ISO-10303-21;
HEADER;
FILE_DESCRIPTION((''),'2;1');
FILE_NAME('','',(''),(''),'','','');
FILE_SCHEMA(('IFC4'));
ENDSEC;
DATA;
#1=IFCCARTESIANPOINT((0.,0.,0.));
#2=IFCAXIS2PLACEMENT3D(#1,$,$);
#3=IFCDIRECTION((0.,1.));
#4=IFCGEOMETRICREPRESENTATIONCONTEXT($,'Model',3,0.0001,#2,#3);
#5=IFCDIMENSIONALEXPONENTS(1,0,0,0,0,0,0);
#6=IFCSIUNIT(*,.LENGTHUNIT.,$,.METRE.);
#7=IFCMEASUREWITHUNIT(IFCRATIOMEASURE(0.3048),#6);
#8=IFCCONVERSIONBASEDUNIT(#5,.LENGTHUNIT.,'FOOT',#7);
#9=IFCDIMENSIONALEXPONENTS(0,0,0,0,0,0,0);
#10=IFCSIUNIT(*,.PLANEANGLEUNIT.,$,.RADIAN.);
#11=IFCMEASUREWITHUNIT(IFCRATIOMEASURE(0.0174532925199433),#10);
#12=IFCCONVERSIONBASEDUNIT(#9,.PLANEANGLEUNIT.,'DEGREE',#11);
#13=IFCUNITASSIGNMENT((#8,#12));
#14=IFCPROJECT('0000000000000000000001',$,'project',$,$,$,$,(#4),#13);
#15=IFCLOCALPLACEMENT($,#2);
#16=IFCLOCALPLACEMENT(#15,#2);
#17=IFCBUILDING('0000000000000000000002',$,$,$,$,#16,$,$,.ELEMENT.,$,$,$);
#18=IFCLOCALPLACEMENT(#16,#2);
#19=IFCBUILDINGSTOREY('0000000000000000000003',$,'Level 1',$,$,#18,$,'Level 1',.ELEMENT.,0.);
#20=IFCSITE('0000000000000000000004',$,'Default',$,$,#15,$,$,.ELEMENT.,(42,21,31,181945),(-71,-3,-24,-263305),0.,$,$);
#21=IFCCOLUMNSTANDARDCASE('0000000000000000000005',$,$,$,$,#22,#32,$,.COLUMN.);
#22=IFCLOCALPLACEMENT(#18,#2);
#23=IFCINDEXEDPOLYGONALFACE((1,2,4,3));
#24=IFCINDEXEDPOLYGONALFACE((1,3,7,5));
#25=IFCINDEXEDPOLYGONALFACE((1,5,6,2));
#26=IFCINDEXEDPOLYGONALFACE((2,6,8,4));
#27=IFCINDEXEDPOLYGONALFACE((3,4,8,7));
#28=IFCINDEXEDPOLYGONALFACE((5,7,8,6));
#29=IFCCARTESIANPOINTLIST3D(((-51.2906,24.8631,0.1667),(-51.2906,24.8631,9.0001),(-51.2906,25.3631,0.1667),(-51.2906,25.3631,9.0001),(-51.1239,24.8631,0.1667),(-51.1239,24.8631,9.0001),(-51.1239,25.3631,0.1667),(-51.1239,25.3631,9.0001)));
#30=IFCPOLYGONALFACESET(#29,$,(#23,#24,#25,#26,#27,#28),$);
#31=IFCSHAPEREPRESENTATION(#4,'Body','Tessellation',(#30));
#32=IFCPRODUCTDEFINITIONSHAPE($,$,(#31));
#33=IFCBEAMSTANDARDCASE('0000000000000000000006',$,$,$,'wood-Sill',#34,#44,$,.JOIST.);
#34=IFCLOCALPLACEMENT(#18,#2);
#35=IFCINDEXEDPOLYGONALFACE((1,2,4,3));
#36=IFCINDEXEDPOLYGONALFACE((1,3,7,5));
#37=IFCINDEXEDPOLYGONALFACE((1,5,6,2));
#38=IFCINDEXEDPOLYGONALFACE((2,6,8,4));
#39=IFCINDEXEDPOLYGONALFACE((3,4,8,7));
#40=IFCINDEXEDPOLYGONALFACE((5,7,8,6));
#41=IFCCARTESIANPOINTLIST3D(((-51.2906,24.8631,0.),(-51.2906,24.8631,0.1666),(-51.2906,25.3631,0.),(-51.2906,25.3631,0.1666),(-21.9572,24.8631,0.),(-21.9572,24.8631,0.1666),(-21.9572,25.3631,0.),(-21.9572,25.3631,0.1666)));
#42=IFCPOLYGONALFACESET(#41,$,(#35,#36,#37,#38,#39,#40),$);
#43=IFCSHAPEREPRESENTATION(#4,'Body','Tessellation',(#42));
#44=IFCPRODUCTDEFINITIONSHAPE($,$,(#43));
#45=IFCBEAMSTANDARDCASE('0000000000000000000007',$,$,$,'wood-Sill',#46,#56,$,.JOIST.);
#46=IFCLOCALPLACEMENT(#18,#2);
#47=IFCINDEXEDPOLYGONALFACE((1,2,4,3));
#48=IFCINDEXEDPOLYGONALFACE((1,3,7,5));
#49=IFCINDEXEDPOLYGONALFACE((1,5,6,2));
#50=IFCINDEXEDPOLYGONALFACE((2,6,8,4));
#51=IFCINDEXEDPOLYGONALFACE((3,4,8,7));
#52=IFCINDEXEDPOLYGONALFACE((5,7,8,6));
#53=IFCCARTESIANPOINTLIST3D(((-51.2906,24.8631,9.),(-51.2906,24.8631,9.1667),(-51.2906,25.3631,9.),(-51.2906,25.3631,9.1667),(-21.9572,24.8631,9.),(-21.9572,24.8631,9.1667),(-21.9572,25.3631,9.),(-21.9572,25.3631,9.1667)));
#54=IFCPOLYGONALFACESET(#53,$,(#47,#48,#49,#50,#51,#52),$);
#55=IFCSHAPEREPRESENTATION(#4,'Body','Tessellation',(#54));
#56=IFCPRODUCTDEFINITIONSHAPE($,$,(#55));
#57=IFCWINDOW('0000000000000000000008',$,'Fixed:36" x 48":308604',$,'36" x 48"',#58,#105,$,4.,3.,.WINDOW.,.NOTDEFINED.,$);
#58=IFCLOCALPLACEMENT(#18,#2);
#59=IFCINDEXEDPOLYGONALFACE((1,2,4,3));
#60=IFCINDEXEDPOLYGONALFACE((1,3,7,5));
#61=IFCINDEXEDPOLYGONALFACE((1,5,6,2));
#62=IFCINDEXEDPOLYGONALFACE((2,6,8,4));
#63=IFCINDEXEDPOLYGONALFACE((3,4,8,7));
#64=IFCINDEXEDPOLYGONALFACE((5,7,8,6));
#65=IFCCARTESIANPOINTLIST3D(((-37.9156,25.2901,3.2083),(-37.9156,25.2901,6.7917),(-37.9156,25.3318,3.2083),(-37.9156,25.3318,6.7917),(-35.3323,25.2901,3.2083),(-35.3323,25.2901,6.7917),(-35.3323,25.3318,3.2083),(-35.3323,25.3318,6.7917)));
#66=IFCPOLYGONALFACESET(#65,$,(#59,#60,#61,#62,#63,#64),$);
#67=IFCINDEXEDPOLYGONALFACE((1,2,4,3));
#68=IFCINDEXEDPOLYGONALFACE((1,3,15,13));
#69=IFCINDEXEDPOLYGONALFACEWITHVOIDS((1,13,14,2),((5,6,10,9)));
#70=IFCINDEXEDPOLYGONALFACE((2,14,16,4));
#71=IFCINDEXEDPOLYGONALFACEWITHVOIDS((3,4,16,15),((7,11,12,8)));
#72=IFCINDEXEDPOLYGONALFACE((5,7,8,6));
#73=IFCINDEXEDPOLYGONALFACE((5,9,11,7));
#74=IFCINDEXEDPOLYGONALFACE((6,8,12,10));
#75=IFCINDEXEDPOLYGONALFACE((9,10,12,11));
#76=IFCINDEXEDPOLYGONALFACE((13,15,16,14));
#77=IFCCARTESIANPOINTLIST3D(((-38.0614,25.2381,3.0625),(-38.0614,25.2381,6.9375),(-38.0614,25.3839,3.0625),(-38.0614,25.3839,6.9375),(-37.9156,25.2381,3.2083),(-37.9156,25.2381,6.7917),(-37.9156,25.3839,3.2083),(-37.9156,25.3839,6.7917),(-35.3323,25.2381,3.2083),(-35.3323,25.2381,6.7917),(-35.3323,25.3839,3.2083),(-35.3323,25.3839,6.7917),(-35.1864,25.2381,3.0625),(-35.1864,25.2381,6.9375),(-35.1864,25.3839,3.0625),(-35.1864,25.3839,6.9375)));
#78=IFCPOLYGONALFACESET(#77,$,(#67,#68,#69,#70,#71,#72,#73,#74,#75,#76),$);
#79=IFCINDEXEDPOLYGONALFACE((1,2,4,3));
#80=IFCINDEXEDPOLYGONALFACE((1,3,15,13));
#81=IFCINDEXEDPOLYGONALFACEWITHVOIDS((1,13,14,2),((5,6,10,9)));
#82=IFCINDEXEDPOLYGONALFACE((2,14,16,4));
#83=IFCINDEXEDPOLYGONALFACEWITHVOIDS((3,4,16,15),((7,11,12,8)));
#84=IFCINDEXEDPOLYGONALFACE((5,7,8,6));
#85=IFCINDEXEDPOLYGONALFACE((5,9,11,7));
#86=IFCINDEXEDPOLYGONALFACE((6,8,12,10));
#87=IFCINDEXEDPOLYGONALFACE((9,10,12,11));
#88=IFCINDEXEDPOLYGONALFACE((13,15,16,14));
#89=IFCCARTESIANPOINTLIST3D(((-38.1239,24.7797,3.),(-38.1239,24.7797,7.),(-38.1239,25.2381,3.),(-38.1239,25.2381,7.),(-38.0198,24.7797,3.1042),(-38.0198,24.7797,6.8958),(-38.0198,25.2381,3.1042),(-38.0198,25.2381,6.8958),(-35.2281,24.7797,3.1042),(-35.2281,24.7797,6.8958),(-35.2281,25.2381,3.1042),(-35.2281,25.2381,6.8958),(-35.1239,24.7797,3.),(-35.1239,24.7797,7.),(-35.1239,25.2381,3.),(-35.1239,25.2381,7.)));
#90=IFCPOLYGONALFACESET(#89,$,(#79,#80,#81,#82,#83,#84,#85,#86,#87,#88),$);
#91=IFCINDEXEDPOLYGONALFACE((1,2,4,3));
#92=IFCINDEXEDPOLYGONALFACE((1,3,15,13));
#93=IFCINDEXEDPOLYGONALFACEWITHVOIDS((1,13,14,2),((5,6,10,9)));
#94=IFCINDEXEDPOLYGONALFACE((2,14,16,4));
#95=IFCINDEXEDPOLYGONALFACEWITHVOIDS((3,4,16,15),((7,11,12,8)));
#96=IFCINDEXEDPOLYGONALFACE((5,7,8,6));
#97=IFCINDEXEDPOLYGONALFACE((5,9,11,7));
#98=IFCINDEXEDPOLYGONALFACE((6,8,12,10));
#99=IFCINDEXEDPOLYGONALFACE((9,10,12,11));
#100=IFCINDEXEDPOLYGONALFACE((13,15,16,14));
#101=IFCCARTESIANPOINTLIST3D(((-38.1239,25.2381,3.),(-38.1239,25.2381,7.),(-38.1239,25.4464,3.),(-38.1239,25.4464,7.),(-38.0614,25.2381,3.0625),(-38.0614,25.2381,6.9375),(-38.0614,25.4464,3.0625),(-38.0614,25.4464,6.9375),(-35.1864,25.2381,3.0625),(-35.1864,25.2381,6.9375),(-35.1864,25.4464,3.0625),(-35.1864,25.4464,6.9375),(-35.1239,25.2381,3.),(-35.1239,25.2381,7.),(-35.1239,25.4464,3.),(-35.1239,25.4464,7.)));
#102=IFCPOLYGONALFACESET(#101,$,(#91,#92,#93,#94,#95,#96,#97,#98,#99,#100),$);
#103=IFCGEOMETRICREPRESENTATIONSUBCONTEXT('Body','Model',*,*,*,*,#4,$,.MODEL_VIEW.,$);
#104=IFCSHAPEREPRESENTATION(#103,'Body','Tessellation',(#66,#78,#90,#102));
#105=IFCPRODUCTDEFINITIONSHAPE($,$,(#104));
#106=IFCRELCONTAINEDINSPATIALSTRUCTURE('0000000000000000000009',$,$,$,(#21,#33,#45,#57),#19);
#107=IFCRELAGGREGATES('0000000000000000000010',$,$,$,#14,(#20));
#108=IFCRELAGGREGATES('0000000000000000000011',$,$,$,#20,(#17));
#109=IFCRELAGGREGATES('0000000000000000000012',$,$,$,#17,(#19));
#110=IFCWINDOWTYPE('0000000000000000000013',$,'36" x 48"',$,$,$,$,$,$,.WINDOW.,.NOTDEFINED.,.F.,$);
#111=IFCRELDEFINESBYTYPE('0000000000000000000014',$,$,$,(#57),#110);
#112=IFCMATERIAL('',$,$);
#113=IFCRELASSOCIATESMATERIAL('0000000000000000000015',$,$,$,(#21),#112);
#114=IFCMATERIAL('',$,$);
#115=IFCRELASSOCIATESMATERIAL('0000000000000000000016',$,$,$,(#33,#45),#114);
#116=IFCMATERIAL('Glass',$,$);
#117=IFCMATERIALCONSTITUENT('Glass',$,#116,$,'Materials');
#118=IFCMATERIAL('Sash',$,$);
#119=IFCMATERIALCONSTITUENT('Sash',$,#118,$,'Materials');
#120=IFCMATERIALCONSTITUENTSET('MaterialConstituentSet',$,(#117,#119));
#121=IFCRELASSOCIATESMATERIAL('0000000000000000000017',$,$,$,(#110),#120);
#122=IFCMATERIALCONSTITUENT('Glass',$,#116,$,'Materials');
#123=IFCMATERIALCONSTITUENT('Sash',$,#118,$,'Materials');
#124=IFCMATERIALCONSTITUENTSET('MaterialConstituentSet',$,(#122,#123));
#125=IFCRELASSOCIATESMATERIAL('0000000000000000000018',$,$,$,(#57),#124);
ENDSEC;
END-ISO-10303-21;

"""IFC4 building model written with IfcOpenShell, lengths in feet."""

from ifc_helpers import new_model, entity, si_unit, converted_unit, direction, frame, frame_2d, origin, origin_with_axes, place, context, subcontext, project, spatial, polyline, rectangle, outline, extrude, source, transform, mapped, material, constituent, constituent_set, type_object, type_shapes, element, save


model = new_model("IFC4")

# Units and contexts
model_context = context("Model", 3, precision=0.0001, world=origin(), true_north=direction((0.0, 1.0)))
body_context = subcontext(model_context, "Body", "Model", "MODEL_VIEW")
ifc_project = project(units=[converted_unit("LENGTHUNIT", "FOOT", entity("IfcRatioMeasure", 0.3048), si_unit("LENGTHUNIT", "METRE"), dimensions=[1, 0, 0, 0, 0, 0, 0]), converted_unit("PLANEANGLEUNIT", "DEGREE", entity("IfcRatioMeasure", 0.0174532925199433), si_unit("PLANEANGLEUNIT", "RADIAN"), dimensions=[0, 0, 0, 0, 0, 0, 0])], contexts=[model_context])

# Site, building, storey
site_placement = place(None, origin())
site = spatial("IfcSite", under=ifc_project, at=site_placement, Name="Default", CompositionType="ELEMENT", RefLatitude=(42, 21, 31, 181945), RefLongitude=(-71, -3, -24, -263305), RefElevation=0.0)
building_placement = place(site_placement, origin())
building = spatial("IfcBuilding", under=site, at=building_placement, CompositionType="ELEMENT")
storey_placement = place(building_placement, origin())
storey = spatial("IfcBuildingStorey", under=building, at=storey_placement, Name="Level 1", LongName="Level 1", CompositionType="ELEMENT", Elevation=0.0)

# Column
ifc_material_1 = material(Name="")
placement_1 = place(storey_placement, frame((-51.2906, 25.1131, 0.0)))
for number, where, z_axis, x_axis in (
    (1, (0.0833, 0.0, 0.1667), (0.0, 0.0, 1.0), (1.0, 0.0, 0.0)),
):
    element("IfcColumnStandardCase", number, at=place(placement_1, frame(where, z_axis=z_axis, x_axis=x_axis)), inside=storey, material=ifc_material_1, PredefinedType="COLUMN", context=model_context, shape_type="SweptSolid", body=[
        extrude(rectangle(XDim=0.1667, YDim=0.5), origin(), (0.0, 0.0, 1.0), 8.8334),
    ])

# Beams
ifc_material_2 = material(Name="")
for number, where, z_axis, x_axis in (
    (2, (0.0, 0.0, 0.0833), (1.0, 0.0, 0.0), (0.0, 0.0, 1.0)),
    (3, (0.0, 0.0, 9.0834), (1.0, 0.0, 0.0), (0.0, 0.0, 1.0)),
):
    element("IfcBeamStandardCase", number, at=place(placement_1, frame(where, z_axis=z_axis, x_axis=x_axis)), inside=storey, material=ifc_material_2, ObjectType="wood-Sill", PredefinedType="JOIST", context=model_context, shape_type="SweptSolid", body=[
        extrude(rectangle(XDim=0.1667, YDim=0.5), origin_with_axes(), (0.0, 0.0, 1.0), 29.3334),
    ])

# Window
ifc_material_3 = material(Name="Glass")
ifc_constituent_1 = constituent(ifc_material_3, Name="Glass", Category="Materials")
ifc_material_4 = material(Name="Sash")
ifc_constituent_2 = constituent(ifc_material_4, Name="Sash", Category="Materials")
ifc_constituent_set_1 = constituent_set(constituents=[ifc_constituent_1, ifc_constituent_2], Name="MaterialConstituentSet")
ifc_constituent_3 = constituent(ifc_material_3, Name="Glass", Category="Materials")
ifc_constituent_4 = constituent(ifc_material_4, Name="Sash", Category="Materials")
ifc_constituent_set_2 = constituent_set(constituents=[ifc_constituent_3, ifc_constituent_4], Name="MaterialConstituentSet")
window_type = type_object("IfcWindowType", Name="36\" x 48\"", ParameterTakesPrecedence=False, PartitioningType="NOTDEFINED", PredefinedType="WINDOW", material=ifc_constituent_set_2)
shared_shape = source(origin(), body_context, "Body", "SweptSolid", [
    extrude(rectangle(XDim=0.0417, YDim=2.5833, at=frame_2d((0.0, 0.0), x_axis=(1.0, 0.0))), frame((1.5, 0.5312, 0.2083), z_axis=(0.0, 0.0, 1.0), x_axis=(0.0, 1.0, 0.0)), (0.0, 0.0, 1.0), 3.5833),
    extrude(outline(polyline([(-1.4375, -1.9375), (1.4375, -1.9375), (1.4375, 1.9375), (-1.4375, 1.9375), (-1.4375, -1.9375)]), holes=[polyline([(-1.2917, -1.7917), (-1.2917, 1.7917), (1.2917, 1.7917), (1.2917, -1.7917), (-1.2917, -1.7917)])]), frame((1.5, 0.4583, 2.0), z_axis=(0.0, 1.0, 0.0), x_axis=(1.0, 0.0, 0.0)), (0.0, 0.0, 1.0), 0.1458),
    extrude(outline(polyline([(-1.5, -2.0), (1.5, -2.0), (1.5, 2.0), (-1.5, 2.0), (-1.5, -2.0)]), holes=[polyline([(-1.3958, -1.8958), (-1.3958, 1.8958), (1.3958, 1.8958), (1.3958, -1.8958), (-1.3958, -1.8958)])]), frame((1.5, 0.0, 2.0), z_axis=(0.0, 1.0, 0.0), x_axis=(1.0, 0.0, 0.0)), (0.0, 0.0, 1.0), 0.4583),
    extrude(outline(polyline([(-2.0, -1.5), (2.0, -1.5), (2.0, 1.5), (-2.0, 1.5), (-2.0, -1.5)]), holes=[polyline([(-1.9375, -1.4375), (-1.9375, 1.4375), (1.9375, 1.4375), (1.9375, -1.4375), (-1.9375, -1.4375)])]), frame((1.5, 0.4583, 2.0), z_axis=(0.0, 1.0, 0.0), x_axis=(0.0, 0.0, -1.0)), (0.0, 0.0, 1.0), 0.2083),
])
type_shapes(window_type, [shared_shape])
placement_2 = place(placement_1, frame((13.1667, -0.3333, 3.0)))
window_placement = place(placement_2, origin())
element("IfcWindow", 4, at=window_placement, inside=storey, type_object=window_type, material=ifc_constituent_set_1, Name="Fixed:36\" x 48\":308604", ObjectType="36\" x 48\"", OverallHeight=4.0, OverallWidth=3.0, PartitioningType="NOTDEFINED", PredefinedType="WINDOW", context=body_context, shape_type="MappedRepresentation", body=[
    mapped(shared_shape, transform((0.0, 0.0, 0.0), scale=1.0)),
])

save(model, "model.ifc")
